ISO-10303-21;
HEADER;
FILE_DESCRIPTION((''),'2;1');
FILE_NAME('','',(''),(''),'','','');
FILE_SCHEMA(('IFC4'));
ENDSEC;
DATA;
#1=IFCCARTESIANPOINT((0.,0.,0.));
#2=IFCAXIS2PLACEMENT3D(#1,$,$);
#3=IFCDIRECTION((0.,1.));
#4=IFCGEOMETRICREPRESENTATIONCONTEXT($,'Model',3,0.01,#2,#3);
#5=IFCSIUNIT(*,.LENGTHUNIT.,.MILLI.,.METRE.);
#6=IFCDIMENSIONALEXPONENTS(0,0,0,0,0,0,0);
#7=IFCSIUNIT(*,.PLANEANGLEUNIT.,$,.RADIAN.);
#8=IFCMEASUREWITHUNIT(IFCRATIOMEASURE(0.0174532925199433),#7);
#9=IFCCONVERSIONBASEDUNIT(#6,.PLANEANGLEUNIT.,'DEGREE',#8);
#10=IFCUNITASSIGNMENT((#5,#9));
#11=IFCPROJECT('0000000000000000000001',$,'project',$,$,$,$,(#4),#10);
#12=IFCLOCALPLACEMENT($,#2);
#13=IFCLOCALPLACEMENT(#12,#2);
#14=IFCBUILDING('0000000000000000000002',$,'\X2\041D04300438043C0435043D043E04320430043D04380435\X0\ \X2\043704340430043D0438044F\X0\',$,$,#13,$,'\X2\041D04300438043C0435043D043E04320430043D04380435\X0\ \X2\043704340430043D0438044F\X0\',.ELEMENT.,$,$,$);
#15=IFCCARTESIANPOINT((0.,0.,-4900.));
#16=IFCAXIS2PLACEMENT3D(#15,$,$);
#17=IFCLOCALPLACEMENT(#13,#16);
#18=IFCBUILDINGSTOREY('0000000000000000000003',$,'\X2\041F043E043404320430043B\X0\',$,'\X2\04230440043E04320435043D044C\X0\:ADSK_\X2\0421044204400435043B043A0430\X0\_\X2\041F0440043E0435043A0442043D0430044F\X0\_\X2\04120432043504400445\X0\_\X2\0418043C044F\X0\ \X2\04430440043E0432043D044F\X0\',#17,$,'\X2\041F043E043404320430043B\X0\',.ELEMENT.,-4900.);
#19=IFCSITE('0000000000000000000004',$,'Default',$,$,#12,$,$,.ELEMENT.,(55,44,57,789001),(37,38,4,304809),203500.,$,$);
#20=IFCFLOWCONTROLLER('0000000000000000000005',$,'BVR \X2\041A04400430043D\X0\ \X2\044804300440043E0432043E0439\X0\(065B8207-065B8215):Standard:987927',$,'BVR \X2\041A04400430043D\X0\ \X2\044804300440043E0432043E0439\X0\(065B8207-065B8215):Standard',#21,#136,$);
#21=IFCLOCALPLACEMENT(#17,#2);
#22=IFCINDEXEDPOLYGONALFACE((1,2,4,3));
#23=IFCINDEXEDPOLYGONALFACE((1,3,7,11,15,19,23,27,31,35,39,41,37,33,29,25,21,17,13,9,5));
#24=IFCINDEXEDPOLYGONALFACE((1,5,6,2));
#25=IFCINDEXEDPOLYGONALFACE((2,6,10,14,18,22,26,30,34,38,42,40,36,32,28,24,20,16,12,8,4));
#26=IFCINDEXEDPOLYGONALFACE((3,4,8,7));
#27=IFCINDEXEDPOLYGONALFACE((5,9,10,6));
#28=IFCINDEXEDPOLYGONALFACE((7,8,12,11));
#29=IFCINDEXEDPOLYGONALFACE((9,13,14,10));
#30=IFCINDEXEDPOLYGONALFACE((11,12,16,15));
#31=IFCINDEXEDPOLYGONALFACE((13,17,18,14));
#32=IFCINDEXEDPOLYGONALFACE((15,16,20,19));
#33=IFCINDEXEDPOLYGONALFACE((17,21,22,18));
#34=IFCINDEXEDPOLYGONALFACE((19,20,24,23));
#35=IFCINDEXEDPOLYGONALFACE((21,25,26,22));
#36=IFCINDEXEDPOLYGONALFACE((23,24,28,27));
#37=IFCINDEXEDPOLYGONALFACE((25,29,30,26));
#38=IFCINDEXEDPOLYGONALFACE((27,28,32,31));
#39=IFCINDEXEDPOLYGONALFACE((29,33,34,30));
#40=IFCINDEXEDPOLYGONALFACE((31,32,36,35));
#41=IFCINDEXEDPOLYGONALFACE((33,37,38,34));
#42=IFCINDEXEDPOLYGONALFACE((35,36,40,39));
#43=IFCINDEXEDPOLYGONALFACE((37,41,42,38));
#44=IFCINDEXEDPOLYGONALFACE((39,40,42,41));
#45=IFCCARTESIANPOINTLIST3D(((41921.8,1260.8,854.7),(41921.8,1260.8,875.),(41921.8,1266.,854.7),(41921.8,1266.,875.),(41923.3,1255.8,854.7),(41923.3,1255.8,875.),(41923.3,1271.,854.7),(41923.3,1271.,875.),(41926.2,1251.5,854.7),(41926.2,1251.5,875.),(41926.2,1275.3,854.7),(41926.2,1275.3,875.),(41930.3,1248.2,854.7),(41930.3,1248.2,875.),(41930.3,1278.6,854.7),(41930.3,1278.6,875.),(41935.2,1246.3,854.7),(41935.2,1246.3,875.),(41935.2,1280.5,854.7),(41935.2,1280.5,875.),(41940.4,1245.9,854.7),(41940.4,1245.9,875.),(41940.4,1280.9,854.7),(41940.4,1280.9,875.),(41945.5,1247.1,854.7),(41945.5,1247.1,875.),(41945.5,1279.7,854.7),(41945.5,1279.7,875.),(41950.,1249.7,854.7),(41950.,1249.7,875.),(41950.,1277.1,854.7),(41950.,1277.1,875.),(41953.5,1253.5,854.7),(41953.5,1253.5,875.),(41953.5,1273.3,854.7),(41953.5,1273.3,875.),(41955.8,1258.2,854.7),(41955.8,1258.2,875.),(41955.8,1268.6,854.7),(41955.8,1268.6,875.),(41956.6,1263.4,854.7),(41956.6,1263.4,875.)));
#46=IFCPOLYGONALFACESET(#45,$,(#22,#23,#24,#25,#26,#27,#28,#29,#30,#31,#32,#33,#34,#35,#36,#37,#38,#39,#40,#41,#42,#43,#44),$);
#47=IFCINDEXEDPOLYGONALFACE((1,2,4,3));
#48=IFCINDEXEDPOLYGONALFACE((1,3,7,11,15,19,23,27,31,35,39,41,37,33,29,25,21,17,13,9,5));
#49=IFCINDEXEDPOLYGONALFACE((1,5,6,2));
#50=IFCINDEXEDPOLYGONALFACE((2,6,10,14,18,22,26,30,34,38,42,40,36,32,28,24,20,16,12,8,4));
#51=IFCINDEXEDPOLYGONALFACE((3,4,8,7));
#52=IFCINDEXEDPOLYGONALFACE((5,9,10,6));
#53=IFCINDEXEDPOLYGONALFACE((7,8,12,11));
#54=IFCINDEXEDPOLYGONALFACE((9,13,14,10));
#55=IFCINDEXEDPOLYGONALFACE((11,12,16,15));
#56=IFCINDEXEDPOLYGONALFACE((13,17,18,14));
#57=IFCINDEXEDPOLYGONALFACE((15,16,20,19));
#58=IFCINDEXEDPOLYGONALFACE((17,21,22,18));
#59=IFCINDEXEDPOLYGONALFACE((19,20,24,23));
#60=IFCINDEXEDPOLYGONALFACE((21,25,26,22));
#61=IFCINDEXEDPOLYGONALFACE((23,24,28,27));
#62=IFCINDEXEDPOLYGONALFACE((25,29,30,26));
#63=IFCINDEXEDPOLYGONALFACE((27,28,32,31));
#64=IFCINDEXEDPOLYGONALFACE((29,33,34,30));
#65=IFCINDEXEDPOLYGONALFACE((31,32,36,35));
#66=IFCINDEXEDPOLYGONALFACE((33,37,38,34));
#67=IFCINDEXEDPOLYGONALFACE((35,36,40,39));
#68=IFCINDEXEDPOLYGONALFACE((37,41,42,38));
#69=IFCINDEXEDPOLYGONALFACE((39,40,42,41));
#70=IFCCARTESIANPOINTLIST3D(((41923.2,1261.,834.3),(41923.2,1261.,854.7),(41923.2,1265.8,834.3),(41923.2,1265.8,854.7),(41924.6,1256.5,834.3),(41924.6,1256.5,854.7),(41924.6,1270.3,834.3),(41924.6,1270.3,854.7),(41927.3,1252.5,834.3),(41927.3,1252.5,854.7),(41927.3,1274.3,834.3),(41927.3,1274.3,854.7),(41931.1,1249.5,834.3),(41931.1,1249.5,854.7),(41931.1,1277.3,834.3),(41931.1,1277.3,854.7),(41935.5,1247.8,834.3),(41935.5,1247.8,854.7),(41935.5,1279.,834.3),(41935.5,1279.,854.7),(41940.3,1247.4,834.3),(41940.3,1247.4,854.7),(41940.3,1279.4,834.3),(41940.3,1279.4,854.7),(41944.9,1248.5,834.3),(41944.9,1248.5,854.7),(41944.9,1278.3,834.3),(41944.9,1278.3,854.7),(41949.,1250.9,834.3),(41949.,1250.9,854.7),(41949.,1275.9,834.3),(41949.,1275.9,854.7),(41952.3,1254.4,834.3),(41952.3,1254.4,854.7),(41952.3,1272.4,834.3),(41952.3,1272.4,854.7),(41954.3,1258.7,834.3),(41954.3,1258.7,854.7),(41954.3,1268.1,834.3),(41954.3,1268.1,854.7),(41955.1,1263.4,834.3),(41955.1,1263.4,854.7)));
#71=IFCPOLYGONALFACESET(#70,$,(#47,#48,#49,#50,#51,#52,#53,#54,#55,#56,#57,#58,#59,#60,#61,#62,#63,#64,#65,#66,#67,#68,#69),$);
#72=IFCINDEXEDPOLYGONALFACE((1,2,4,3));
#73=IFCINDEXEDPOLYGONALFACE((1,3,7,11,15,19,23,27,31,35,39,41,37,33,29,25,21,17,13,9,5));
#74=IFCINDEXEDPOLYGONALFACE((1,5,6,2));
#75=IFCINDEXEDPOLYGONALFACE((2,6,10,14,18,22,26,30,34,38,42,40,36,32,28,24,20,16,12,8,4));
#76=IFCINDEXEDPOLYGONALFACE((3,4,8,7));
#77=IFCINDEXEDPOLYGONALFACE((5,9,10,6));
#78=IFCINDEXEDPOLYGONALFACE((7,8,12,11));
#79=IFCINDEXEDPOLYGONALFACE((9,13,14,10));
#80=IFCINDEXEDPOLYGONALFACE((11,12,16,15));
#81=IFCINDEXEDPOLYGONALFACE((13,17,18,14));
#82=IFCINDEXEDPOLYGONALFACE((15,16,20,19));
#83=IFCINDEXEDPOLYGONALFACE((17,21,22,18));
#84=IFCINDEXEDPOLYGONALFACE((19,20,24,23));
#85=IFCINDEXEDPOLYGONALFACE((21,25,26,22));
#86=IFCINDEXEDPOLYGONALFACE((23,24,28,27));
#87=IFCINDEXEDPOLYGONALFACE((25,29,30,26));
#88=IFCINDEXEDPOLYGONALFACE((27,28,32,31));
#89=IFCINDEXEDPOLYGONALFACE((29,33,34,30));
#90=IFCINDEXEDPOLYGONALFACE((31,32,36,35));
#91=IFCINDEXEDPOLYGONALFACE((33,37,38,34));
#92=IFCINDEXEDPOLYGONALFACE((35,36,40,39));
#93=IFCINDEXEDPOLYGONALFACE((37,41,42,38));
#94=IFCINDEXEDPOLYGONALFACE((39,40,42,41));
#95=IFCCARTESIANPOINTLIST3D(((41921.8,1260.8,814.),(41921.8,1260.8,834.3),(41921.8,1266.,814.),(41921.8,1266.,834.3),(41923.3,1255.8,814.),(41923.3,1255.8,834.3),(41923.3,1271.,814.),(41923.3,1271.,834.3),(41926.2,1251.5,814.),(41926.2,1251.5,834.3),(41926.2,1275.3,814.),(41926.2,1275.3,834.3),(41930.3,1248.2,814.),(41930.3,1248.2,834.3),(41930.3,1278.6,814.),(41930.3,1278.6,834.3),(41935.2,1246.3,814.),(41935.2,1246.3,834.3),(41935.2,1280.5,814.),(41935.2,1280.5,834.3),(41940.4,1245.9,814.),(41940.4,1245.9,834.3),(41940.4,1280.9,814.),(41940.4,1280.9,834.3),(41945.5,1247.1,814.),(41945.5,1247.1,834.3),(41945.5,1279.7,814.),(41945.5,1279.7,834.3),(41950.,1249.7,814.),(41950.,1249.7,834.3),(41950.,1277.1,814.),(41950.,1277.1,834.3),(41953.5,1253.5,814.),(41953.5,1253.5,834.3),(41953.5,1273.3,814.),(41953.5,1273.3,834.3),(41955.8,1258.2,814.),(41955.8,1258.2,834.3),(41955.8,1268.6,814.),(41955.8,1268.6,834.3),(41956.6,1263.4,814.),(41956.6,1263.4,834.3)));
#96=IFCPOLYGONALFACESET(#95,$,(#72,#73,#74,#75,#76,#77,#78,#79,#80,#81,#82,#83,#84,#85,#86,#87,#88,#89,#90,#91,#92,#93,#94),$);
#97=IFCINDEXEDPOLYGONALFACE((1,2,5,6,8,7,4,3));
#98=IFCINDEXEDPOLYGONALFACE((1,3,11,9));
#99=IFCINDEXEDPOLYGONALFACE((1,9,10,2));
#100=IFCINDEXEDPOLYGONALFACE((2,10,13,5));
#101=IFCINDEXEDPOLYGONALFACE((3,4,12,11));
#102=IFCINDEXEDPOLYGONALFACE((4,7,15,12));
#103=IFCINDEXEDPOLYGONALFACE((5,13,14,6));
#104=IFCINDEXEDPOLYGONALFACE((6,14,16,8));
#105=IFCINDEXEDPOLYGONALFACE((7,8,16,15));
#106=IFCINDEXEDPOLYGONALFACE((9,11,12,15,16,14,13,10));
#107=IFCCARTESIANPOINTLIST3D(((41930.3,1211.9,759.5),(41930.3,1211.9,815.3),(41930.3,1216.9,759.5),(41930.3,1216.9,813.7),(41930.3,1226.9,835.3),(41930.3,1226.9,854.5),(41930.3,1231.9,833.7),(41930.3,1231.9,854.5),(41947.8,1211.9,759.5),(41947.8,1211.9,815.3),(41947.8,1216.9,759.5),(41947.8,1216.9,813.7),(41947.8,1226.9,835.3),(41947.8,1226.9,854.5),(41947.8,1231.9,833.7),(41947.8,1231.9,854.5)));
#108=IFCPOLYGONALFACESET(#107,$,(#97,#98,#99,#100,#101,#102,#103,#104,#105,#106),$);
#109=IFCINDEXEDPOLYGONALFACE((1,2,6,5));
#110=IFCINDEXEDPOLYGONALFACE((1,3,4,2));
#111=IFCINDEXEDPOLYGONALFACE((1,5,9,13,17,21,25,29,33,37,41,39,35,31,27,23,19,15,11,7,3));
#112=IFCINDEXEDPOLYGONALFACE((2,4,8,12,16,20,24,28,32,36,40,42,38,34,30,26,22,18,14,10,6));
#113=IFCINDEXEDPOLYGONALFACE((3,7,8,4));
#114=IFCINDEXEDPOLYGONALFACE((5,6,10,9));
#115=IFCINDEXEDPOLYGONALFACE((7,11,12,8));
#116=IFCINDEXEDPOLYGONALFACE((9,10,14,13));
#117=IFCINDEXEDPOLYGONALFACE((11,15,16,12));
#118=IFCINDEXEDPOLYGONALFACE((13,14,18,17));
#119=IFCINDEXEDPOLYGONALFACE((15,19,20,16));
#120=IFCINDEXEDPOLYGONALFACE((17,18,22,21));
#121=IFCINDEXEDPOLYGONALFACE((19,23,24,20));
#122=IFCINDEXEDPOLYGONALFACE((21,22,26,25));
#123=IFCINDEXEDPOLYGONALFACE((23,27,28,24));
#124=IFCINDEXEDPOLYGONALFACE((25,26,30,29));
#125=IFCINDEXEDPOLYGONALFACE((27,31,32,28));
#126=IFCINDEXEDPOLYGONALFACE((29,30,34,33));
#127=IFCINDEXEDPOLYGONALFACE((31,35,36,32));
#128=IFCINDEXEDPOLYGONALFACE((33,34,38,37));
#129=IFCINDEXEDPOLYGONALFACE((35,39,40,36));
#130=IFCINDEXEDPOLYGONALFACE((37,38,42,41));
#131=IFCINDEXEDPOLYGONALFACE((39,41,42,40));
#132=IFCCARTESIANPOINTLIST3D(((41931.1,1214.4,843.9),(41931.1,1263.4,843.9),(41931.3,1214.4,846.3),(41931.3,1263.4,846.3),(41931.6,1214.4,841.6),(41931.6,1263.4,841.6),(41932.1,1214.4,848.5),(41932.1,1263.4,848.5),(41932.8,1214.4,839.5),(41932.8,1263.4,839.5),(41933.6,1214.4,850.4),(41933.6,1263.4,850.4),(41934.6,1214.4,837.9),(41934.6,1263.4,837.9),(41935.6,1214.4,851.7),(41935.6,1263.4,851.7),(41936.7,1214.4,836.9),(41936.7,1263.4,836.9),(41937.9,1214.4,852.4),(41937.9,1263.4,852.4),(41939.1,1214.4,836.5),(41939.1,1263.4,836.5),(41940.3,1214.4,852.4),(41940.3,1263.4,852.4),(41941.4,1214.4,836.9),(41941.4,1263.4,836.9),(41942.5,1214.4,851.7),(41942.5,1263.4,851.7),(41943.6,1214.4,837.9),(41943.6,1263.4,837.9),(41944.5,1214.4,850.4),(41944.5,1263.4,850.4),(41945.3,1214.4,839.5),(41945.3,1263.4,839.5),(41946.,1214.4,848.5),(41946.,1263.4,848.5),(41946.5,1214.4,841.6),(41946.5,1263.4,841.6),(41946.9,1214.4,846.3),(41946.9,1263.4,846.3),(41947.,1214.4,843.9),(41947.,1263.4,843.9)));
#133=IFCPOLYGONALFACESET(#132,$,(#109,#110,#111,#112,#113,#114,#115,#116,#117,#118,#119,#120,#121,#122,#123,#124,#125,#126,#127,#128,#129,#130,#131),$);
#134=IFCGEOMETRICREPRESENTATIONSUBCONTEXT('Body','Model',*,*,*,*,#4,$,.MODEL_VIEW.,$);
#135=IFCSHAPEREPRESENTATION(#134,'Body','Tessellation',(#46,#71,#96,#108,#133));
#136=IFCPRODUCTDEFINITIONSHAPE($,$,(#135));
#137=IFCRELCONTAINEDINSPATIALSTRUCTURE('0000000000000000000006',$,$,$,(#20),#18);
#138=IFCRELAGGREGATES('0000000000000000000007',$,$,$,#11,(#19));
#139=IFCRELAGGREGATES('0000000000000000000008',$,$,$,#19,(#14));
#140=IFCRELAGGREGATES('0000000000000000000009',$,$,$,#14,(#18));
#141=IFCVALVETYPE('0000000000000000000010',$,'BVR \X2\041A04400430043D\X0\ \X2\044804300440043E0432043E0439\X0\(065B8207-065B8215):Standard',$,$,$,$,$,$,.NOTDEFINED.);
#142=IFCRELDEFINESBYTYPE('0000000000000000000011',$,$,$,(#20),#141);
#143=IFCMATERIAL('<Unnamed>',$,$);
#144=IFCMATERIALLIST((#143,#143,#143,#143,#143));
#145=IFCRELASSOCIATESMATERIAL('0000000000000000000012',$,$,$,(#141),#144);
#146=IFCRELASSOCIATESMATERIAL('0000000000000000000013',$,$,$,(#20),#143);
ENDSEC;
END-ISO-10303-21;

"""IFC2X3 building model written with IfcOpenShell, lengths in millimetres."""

from ifc_helpers import new_model, entity, si_unit, converted_unit, direction, frame, origin, origin_2d_with_axis, place, context, subcontext, project, spatial, polyline, circle, outline, extrude, source, transform, mapped, material, material_list, type_object, type_shapes, element, save


model = new_model("IFC2X3")

# Units and contexts
model_context = context("Model", 3, precision=0.01, world=origin(), true_north=direction((0.0, 1.0)))
body_context = subcontext(model_context, "Body", "Model", "MODEL_VIEW")
ifc_project = project(units=[si_unit("LENGTHUNIT", "METRE", prefix="MILLI"), converted_unit("PLANEANGLEUNIT", "DEGREE", entity("IfcRatioMeasure", 0.0174532925199433), si_unit("PLANEANGLEUNIT", "RADIAN"), dimensions=[0, 0, 0, 0, 0, 0, 0])], contexts=[model_context])

# Site, building, storey
site_placement = place(None, origin())
site = spatial("IfcSite", under=ifc_project, at=site_placement, Name="Default", CompositionType="ELEMENT", RefLatitude=(55, 44, 57, 789001), RefLongitude=(37, 38, 4, 304809), RefElevation=203500.0)
building_placement = place(site_placement, origin())
building = spatial("IfcBuilding", under=site, at=building_placement, Name="Наименование здания", LongName="Наименование здания", CompositionType="ELEMENT")
storey_placement = place(building_placement, frame((0.0, 0.0, -4900.0)))
storey = spatial("IfcBuildingStorey", under=building, at=storey_placement, Name="Подвал", ObjectType="Уровень:ADSK_Стрелка_Проектная_Вверх_Имя уровня", LongName="Подвал", CompositionType="ELEMENT", Elevation=-4900.0)

# Flow controller
ifc_material = material(Name="<Unnamed>")
ifc_material_list = material_list([ifc_material, ifc_material, ifc_material, ifc_material, ifc_material])
valve_type = type_object("IfcValveType", Name="BVR Кран шаровой(065B8207-065B8215):Standard", PredefinedType="NOTDEFINED", material=ifc_material_list)
shared_shape = source(origin(), body_context, "Body", "SweptSolid", [
    extrude(circle(Radius=17.5, at=origin_2d_with_axis()), frame((-30.5, 0.0, 0.0), z_axis=(1.0, 0.0, 0.0), x_axis=(0.0, 1.0, 0.0)), (0.0, 0.0, 1.0), 20.3),
    extrude(circle(Radius=16.0, at=origin_2d_with_axis()), frame((-10.2, 0.0, 0.0), z_axis=(1.0, 0.0, 0.0), x_axis=(0.0, 1.0, 0.0)), (0.0, 0.0, 1.0), 20.3),
    extrude(circle(Radius=17.5, at=origin_2d_with_axis()), frame((10.2, 0.0, 0.0), z_axis=(1.0, 0.0, 0.0), x_axis=(0.0, 1.0, 0.0)), (0.0, 0.0, 1.0), 20.3),
    extrude(outline(polyline([(-38.8, -5.0), (-38.8, -10.0), (-17.9, -10.0), (2.1, 5.0), (56.2, 5.0), (56.2, 10.0), (0.4, 10.0), (-19.6, -5.0), (-38.8, -5.0)])), frame((28.8, -8.8, 41.5), z_axis=(0.0, -1.0, 0.0), x_axis=(1.0, 0.0, 0.0)), (0.0, 0.0, -1.0), 17.5),
    extrude(circle(Radius=8.0, at=origin_2d_with_axis()), origin(), (0.0, 0.0, 1.0), 49.0),
])
type_shapes(valve_type, [shared_shape])
for number, where, z_axis, x_axis, name in (
    (1, (41939.1, 1263.4, 844.5), (0.0, -1.0, 0.0), (0.0, 0.0, -1.0), "BVR Кран шаровой(065B8207-065B8215):Standard:987927"),
):
    element("IfcFlowController", number, at=place(storey_placement, frame(where, z_axis=z_axis, x_axis=x_axis)), inside=storey, type_object=valve_type, material=ifc_material, Name=name, ObjectType="BVR Кран шаровой(065B8207-065B8215):Standard", context=body_context, shape_type="MappedRepresentation", body=[
        mapped(shared_shape, transform((0.0, 0.0, 0.0), scale=1.0)),
    ])

save(model, "model.ifc")
